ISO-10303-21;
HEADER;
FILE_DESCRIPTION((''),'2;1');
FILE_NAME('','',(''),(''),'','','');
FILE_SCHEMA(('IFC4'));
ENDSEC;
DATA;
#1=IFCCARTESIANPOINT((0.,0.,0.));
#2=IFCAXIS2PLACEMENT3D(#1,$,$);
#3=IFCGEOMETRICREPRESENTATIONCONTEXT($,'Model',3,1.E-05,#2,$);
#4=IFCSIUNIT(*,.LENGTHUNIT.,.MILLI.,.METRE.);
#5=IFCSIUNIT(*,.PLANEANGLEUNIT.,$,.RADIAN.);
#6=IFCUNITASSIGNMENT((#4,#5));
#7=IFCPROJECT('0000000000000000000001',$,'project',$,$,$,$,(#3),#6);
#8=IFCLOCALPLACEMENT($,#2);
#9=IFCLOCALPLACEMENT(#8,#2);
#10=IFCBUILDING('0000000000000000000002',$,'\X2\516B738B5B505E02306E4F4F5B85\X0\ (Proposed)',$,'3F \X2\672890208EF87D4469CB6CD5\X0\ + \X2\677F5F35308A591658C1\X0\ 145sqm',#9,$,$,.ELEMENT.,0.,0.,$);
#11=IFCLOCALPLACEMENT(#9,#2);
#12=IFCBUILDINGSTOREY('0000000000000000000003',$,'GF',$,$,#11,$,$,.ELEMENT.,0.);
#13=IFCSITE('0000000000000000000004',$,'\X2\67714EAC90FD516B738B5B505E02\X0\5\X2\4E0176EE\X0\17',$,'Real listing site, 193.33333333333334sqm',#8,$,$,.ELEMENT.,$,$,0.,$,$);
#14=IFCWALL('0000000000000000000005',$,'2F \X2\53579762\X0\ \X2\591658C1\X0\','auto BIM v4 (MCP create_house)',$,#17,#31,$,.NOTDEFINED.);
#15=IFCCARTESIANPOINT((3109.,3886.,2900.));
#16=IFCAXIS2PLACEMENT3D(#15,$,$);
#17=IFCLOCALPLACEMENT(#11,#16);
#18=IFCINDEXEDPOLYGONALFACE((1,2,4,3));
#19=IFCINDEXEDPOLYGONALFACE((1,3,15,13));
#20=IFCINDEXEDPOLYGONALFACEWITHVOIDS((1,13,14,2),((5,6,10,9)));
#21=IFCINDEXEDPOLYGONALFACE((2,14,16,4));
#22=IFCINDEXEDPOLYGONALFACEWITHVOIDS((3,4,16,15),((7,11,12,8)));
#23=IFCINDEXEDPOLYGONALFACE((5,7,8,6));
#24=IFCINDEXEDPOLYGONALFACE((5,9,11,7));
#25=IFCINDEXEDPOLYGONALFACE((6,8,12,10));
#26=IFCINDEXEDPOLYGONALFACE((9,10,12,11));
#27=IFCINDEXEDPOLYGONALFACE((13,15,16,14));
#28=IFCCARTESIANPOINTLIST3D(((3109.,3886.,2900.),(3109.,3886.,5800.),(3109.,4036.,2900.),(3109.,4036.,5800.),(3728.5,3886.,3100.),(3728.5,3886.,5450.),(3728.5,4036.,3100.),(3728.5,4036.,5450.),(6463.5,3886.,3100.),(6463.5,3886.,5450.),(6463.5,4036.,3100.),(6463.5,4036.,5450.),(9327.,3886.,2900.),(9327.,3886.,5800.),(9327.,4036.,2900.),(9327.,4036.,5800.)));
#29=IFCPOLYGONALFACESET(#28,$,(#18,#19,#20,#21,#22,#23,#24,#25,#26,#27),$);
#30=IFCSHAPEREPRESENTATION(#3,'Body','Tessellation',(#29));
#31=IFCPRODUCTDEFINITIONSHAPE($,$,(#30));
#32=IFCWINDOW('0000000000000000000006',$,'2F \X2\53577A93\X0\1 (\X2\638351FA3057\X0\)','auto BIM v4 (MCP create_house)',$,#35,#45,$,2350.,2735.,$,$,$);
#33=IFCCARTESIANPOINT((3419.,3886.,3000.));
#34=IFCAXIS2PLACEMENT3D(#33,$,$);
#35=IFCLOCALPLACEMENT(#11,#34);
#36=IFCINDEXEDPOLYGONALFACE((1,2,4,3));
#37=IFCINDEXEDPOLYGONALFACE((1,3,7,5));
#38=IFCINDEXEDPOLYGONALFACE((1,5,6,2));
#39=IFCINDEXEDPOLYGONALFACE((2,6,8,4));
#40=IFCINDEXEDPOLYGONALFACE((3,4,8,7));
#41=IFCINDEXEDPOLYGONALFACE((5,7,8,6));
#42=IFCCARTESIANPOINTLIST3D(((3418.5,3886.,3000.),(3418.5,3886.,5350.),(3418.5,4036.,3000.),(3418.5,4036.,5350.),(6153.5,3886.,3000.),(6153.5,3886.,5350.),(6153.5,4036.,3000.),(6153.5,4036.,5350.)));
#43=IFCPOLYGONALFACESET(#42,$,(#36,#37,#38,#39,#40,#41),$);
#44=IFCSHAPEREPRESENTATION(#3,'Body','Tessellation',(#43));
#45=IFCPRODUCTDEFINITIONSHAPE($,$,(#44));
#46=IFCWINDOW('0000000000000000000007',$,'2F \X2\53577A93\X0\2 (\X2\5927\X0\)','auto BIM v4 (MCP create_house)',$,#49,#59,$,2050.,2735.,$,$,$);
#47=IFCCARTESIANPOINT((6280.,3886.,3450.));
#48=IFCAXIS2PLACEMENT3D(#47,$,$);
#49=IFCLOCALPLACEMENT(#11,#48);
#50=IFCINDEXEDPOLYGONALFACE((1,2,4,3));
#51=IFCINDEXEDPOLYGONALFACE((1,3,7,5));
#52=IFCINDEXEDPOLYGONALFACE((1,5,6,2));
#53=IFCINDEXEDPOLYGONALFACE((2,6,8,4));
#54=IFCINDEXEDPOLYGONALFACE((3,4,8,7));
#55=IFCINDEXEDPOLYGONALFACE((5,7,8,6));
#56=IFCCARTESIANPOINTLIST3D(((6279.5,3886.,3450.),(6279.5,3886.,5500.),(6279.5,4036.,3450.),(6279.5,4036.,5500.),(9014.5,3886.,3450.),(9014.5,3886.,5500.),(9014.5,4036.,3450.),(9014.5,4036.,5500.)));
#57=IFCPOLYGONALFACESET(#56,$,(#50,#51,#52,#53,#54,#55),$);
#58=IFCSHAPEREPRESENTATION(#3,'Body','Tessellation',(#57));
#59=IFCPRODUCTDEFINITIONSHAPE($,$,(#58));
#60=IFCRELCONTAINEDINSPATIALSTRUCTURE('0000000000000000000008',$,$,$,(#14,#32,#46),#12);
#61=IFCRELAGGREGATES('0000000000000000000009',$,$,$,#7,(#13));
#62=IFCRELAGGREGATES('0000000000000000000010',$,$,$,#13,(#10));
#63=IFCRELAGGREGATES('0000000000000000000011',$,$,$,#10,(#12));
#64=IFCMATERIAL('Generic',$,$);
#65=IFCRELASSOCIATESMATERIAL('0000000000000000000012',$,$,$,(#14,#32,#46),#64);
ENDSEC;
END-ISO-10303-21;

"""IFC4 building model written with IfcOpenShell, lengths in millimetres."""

from ifc_helpers import new_model, si_unit, frame, frame_2d, origin, place, context, project, spatial, rectangle, extrude, material, element, fill, save


model = new_model("IFC4")

# Units and contexts
model_context = context("Model", 3, precision=1e-05, world=origin())
ifc_project = project(units=[si_unit("LENGTHUNIT", "METRE", prefix="MILLI"), si_unit("PLANEANGLEUNIT", "RADIAN")], contexts=[model_context])

# Site, building, storey
site_placement = place(None, origin())
site = spatial("IfcSite", under=ifc_project, at=site_placement, Name="東京都八王子市5丁目17", ObjectType="Real listing site, 193.33333333333334sqm", CompositionType="ELEMENT", RefElevation=0.0)
building_placement = place(site_placement, origin())
building = spatial("IfcBuilding", under=site, at=building_placement, Name="八王子市の住宅 (Proposed)", ObjectType="3F 木造軸組構法 + 板張り外壁 145sqm", CompositionType="ELEMENT", ElevationOfRefHeight=0.0, ElevationOfTerrain=0.0)
storey_placement = place(building_placement, origin())
storey = spatial("IfcBuildingStorey", under=building, at=storey_placement, Name="GF", CompositionType="ELEMENT", Elevation=0.0)

# Shared definitions
ifc_material = material(Name="Generic")

# Wall, openings, windows
wall_1_placement = place(storey_placement, frame((3109.0, 3886.0, 2900.0)))
wall_1 = element("IfcWall", 1, at=wall_1_placement, inside=storey, material=ifc_material, Name="2F 南面 外壁", Description="auto BIM v4 (MCP create_house)", PredefinedType="NOTDEFINED", context=model_context, shape_type="SweptSolid", body=[
    extrude(rectangle(XDim=6218.0, YDim=150.0, at=frame_2d((3109.0, 75.0))), frame((3109.0, 3886.0, 2900.0)), (0.0, 0.0, 1.0), 2900.0),
])
opening_1_placement = place(storey_placement, frame((3419.0, 3886.0, 3000.0)))
opening_1 = element("IfcOpeningElement", 2, at=opening_1_placement, cuts=wall_1, PredefinedType="NOTDEFINED", context=model_context, shape_type="SweptSolid", body=[
    extrude(rectangle(XDim=2735.0, YDim=150.0, at=frame_2d((1367.0, 75.0))), frame((3419.0, 3886.0, 3000.0)), (0.0, 0.0, 1.0), 2350.0),
])
opening_2_placement = place(storey_placement, frame((6280.0, 3886.0, 3450.0)))
opening_2 = element("IfcOpeningElement", 3, at=opening_2_placement, cuts=wall_1, PredefinedType="NOTDEFINED", context=model_context, shape_type="SweptSolid", body=[
    extrude(rectangle(XDim=2735.0, YDim=150.0, at=frame_2d((1367.0, 75.0))), frame((6280.0, 3886.0, 3450.0)), (0.0, 0.0, 1.0), 2050.0),
])
window_1_placement = place(storey_placement, frame((3419.0, 3886.0, 3000.0)))
window_1 = element("IfcWindow", 4, at=window_1_placement, inside=storey, material=ifc_material, Name="2F 南窓1 (掃出し)", Description="auto BIM v4 (MCP create_house)", OverallHeight=2350.0, OverallWidth=2735.0, context=model_context, shape_type="SweptSolid", body=[
    extrude(rectangle(XDim=2735.0, YDim=150.0, at=frame_2d((1367.0, 75.0))), frame((3419.0, 3886.0, 3000.0)), (0.0, 0.0, 1.0), 2350.0),
])
fill(opening_1, window_1)
window_2_placement = place(storey_placement, frame((6280.0, 3886.0, 3450.0)))
window_2 = element("IfcWindow", 5, at=window_2_placement, inside=storey, material=ifc_material, Name="2F 南窓2 (大)", Description="auto BIM v4 (MCP create_house)", OverallHeight=2050.0, OverallWidth=2735.0, context=model_context, shape_type="SweptSolid", body=[
    extrude(rectangle(XDim=2735.0, YDim=150.0, at=frame_2d((1367.0, 75.0))), frame((6280.0, 3886.0, 3450.0)), (0.0, 0.0, 1.0), 2050.0),
])
fill(opening_2, window_2)

save(model, "model.ifc")
